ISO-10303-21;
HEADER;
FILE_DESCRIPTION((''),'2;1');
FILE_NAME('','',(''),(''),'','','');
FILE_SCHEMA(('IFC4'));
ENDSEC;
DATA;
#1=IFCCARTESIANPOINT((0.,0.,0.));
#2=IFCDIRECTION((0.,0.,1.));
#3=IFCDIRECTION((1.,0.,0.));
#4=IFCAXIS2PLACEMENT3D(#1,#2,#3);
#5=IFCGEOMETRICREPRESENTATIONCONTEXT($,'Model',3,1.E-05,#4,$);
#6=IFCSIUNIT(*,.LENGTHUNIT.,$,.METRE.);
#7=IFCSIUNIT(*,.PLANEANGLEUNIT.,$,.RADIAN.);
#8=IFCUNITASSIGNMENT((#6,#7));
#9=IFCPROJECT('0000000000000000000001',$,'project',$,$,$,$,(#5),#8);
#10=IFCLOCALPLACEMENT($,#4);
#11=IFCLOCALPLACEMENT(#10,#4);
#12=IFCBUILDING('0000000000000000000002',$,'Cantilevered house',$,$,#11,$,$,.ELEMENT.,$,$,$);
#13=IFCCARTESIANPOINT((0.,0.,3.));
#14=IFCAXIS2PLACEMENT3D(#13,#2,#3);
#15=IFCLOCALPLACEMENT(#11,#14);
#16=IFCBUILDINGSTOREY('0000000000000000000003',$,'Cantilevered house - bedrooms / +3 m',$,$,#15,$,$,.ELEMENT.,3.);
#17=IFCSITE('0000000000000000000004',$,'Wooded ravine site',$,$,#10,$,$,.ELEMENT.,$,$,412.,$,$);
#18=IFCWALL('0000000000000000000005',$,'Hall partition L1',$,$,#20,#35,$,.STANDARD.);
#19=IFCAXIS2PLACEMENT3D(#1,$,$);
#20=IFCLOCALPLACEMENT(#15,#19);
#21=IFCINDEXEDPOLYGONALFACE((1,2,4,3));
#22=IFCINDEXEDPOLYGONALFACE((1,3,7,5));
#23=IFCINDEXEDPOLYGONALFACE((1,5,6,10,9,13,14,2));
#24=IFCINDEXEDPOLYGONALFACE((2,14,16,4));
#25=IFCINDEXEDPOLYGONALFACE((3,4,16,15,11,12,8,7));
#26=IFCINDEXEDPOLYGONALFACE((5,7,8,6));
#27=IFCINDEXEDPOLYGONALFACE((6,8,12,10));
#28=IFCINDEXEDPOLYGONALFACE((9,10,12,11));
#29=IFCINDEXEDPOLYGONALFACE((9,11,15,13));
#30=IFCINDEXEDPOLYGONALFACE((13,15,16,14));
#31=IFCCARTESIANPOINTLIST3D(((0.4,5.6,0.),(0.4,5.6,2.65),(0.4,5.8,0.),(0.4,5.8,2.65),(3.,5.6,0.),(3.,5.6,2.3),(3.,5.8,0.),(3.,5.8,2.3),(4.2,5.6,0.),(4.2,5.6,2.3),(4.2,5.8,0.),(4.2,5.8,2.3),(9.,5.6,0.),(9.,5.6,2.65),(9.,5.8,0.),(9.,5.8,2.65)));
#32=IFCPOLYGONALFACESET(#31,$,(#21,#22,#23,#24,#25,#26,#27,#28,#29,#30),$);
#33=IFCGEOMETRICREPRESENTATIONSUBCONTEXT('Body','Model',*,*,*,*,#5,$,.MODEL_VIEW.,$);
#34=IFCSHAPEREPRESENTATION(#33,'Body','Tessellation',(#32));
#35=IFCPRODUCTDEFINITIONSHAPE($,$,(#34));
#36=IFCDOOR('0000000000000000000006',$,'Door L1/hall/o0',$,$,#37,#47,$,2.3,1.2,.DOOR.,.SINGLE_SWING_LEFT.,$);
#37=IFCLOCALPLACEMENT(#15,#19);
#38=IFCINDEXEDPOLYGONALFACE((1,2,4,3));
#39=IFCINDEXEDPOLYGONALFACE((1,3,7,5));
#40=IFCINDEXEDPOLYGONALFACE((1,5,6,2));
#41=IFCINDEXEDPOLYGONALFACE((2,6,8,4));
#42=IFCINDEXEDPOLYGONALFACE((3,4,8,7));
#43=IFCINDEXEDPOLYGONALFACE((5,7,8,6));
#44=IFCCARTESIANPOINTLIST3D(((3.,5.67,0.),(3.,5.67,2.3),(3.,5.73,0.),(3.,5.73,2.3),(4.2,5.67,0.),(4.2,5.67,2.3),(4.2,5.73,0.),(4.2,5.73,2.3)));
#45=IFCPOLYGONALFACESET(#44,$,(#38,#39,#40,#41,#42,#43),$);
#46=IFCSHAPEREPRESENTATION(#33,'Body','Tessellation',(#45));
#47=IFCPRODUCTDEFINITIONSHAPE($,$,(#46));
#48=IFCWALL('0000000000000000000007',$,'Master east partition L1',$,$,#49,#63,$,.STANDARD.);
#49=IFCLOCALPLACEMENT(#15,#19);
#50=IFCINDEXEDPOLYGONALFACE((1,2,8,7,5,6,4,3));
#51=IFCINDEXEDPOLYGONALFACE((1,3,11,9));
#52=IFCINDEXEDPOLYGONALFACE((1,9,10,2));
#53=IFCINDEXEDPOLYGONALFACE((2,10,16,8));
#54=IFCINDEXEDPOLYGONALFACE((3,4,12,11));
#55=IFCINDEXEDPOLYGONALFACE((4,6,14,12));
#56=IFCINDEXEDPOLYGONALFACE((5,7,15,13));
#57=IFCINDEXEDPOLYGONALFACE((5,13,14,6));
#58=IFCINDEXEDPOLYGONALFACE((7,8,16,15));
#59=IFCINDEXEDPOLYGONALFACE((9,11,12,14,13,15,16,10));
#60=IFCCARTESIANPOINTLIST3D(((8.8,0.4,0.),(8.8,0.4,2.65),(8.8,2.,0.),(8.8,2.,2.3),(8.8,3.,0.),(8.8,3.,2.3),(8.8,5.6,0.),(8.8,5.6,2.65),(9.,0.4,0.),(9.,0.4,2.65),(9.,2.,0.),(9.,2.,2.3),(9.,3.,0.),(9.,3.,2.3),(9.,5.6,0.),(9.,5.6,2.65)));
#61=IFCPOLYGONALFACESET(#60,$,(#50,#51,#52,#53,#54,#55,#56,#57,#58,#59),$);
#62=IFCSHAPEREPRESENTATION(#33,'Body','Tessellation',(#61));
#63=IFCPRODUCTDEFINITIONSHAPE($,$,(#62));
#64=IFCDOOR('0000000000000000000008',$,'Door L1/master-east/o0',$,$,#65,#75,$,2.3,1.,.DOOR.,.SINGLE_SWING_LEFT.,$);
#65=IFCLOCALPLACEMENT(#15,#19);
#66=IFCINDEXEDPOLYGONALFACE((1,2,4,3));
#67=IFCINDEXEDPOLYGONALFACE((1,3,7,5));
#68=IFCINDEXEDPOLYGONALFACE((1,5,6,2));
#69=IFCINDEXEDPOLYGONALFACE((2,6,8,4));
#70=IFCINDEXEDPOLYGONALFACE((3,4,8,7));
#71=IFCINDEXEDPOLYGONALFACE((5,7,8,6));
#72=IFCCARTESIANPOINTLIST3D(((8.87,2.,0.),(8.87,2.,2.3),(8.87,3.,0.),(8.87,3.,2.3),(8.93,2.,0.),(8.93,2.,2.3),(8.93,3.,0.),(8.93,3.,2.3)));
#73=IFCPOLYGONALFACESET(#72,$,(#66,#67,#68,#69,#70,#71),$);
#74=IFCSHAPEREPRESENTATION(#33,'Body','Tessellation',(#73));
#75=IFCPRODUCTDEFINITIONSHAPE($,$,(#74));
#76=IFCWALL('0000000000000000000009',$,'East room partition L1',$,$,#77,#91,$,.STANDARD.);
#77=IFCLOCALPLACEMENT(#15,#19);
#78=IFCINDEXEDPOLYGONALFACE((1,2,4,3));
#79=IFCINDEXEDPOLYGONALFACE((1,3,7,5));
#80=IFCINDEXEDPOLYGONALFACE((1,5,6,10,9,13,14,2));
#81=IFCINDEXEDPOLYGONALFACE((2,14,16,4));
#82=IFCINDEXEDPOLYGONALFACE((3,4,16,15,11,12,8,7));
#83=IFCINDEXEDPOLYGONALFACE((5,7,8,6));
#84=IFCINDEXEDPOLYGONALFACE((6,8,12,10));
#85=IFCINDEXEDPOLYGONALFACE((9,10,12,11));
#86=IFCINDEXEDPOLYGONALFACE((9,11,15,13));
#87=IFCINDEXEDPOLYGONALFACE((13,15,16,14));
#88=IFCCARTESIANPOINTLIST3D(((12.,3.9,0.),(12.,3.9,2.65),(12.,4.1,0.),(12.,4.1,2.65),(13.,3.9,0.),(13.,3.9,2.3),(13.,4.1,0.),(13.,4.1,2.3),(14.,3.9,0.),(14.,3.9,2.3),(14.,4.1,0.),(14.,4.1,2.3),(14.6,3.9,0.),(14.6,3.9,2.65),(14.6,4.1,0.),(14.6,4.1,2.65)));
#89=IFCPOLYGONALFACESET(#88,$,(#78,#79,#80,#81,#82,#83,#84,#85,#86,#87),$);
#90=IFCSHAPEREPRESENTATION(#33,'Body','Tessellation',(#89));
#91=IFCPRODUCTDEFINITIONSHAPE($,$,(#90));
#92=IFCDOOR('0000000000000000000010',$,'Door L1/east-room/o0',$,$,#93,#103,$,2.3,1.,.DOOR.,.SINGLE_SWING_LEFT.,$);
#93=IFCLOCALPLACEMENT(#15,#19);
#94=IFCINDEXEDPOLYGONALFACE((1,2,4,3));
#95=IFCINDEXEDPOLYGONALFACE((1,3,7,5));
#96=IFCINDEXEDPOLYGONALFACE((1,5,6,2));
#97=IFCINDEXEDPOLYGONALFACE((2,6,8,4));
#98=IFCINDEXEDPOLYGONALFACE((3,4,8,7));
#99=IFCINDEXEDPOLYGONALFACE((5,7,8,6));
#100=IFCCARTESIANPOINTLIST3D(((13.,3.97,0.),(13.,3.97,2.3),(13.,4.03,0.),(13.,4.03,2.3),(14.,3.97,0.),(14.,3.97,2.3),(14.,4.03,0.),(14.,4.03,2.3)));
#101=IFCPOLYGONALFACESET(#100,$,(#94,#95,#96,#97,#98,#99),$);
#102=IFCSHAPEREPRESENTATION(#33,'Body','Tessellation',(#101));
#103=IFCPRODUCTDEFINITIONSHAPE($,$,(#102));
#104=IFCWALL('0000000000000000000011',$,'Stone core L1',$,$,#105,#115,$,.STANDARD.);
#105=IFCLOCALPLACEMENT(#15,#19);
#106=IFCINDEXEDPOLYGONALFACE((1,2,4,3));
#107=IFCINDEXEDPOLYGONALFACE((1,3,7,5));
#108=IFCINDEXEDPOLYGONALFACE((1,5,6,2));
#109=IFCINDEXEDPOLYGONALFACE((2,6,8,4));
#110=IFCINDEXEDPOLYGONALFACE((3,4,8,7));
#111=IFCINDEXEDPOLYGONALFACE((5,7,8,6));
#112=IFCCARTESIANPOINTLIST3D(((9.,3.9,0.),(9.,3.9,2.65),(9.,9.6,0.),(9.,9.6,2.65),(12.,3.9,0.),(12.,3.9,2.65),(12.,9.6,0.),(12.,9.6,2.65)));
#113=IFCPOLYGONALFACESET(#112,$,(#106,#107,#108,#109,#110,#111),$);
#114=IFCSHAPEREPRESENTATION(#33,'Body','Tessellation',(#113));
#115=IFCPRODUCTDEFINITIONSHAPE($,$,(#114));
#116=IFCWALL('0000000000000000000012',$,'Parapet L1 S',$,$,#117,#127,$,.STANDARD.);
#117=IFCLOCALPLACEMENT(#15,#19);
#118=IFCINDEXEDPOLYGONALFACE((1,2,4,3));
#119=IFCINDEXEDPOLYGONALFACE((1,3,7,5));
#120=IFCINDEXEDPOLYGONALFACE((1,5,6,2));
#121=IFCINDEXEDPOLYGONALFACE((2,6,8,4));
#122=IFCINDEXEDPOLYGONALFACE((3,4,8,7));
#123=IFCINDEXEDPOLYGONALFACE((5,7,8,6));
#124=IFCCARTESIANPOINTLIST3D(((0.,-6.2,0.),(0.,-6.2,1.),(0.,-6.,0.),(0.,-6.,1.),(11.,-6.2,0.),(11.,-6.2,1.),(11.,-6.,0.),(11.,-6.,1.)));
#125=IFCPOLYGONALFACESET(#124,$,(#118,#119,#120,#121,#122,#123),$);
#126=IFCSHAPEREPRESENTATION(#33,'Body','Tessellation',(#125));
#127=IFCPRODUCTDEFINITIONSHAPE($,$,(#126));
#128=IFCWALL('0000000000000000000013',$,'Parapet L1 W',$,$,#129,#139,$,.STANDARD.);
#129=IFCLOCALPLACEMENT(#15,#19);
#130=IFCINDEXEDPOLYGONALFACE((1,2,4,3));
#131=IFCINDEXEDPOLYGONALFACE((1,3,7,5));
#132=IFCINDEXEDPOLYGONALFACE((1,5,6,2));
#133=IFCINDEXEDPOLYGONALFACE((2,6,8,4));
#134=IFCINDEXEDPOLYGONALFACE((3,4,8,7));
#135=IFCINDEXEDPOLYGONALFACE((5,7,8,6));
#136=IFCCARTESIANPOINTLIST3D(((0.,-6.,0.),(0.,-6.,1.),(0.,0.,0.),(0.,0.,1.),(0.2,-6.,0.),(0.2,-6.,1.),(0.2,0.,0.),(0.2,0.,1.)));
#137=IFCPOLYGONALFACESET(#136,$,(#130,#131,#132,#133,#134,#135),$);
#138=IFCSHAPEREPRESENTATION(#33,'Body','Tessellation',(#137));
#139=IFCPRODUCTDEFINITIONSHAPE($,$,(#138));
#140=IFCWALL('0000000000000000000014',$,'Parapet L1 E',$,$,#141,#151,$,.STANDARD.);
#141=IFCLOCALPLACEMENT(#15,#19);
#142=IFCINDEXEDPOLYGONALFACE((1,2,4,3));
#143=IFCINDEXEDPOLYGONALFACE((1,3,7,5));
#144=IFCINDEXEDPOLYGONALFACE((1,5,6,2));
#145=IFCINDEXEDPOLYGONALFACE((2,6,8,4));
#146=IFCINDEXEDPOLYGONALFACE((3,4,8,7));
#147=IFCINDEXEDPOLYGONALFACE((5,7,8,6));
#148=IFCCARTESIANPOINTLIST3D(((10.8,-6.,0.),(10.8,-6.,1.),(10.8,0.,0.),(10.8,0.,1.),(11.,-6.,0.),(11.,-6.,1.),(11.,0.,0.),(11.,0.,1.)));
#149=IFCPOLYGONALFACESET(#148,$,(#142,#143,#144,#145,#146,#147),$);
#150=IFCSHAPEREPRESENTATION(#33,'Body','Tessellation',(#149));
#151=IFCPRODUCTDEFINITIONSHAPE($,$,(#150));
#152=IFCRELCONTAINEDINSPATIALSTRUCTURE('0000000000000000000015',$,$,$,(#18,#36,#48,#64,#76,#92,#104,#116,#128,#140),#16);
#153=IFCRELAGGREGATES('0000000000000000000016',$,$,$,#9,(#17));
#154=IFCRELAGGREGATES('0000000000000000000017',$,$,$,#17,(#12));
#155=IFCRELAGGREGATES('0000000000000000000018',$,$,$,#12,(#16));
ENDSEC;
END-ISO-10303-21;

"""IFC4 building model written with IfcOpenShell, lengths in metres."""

from ifc_helpers import new_model, si_unit, frame, frame_2d, origin_with_axes, place, context, subcontext, project, spatial, rectangle, extrude, element, fill, save


model = new_model("IFC4")

# Units and contexts
model_context = context("Model", 3, precision=1e-05, world=origin_with_axes())
body_context = subcontext(model_context, "Body", "Model", "MODEL_VIEW")
ifc_project = project(units=[si_unit("LENGTHUNIT", "METRE"), si_unit("PLANEANGLEUNIT", "RADIAN")], contexts=[model_context])

# Site, building, storey
site_placement = place(None, origin_with_axes())
site = spatial("IfcSite", under=ifc_project, at=site_placement, Name="Wooded ravine site", CompositionType="ELEMENT", RefElevation=412.0)
building_placement = place(site_placement, origin_with_axes())
building = spatial("IfcBuilding", under=site, at=building_placement, Name="Cantilevered house", CompositionType="ELEMENT")
storey_placement = place(building_placement, frame((0.0, 0.0, 3.0), z_axis=(0.0, 0.0, 1.0), x_axis=(1.0, 0.0, 0.0)))
storey = spatial("IfcBuildingStorey", under=building, at=storey_placement, Name="Cantilevered house - bedrooms / +3 m", CompositionType="ELEMENT", Elevation=3.0)

# Walls, openings, doors
wall_1_placement = place(storey_placement, origin_with_axes())
wall_1 = element("IfcWall", 1, at=wall_1_placement, inside=storey, Name="Hall partition L1", PredefinedType="STANDARD", context=body_context, shape_type="SweptSolid", body=[
    extrude(rectangle(XDim=8.6, YDim=0.2, at=frame_2d((4.7, 5.7))), origin_with_axes(), (0.0, 0.0, 1.0), 2.65),
])
opening_1_placement = place(storey_placement, origin_with_axes())
opening_1 = element("IfcOpeningElement", 2, at=opening_1_placement, inside=storey, cuts=wall_1, PredefinedType="OPENING", context=body_context, shape_type="SweptSolid", body=[
    extrude(rectangle(XDim=1.2, YDim=0.24, at=frame_2d((3.6, 5.7))), origin_with_axes(), (0.0, 0.0, 1.0), 2.3),
])
door_1_placement = place(storey_placement, origin_with_axes())
door_1 = element("IfcDoor", 3, at=door_1_placement, inside=storey, Name="Door L1/hall/o0", OperationType="SINGLE_SWING_LEFT", OverallHeight=2.3, OverallWidth=1.2, PredefinedType="DOOR", context=body_context, shape_type="SweptSolid", body=[
    extrude(rectangle(XDim=1.2, YDim=0.06, at=frame_2d((3.6, 5.7))), origin_with_axes(), (0.0, 0.0, 1.0), 2.3),
])
fill(opening_1, door_1)
wall_2_placement = place(storey_placement, origin_with_axes())
wall_2 = element("IfcWall", 4, at=wall_2_placement, inside=storey, Name="Master east partition L1", PredefinedType="STANDARD", context=body_context, shape_type="SweptSolid", body=[
    extrude(rectangle(XDim=0.2, YDim=5.2, at=frame_2d((8.9, 3.0))), origin_with_axes(), (0.0, 0.0, 1.0), 2.65),
])
opening_2_placement = place(storey_placement, origin_with_axes())
opening_2 = element("IfcOpeningElement", 5, at=opening_2_placement, inside=storey, cuts=wall_2, PredefinedType="OPENING", context=body_context, shape_type="SweptSolid", body=[
    extrude(rectangle(XDim=0.24, YDim=1.0, at=frame_2d((8.9, 2.5))), origin_with_axes(), (0.0, 0.0, 1.0), 2.3),
])
door_2_placement = place(storey_placement, origin_with_axes())
door_2 = element("IfcDoor", 6, at=door_2_placement, inside=storey, Name="Door L1/master-east/o0", OperationType="SINGLE_SWING_LEFT", OverallHeight=2.3, OverallWidth=1.0, PredefinedType="DOOR", context=body_context, shape_type="SweptSolid", body=[
    extrude(rectangle(XDim=0.06, YDim=1.0, at=frame_2d((8.9, 2.5))), origin_with_axes(), (0.0, 0.0, 1.0), 2.3),
])
fill(opening_2, door_2)
wall_3_placement = place(storey_placement, origin_with_axes())
wall_3 = element("IfcWall", 7, at=wall_3_placement, inside=storey, Name="East room partition L1", PredefinedType="STANDARD", context=body_context, shape_type="SweptSolid", body=[
    extrude(rectangle(XDim=2.6, YDim=0.2, at=frame_2d((13.3, 4.0))), origin_with_axes(), (0.0, 0.0, 1.0), 2.65),
])
opening_3_placement = place(storey_placement, origin_with_axes())
opening_3 = element("IfcOpeningElement", 8, at=opening_3_placement, inside=storey, cuts=wall_3, PredefinedType="OPENING", context=body_context, shape_type="SweptSolid", body=[
    extrude(rectangle(XDim=1.0, YDim=0.24, at=frame_2d((13.5, 4.0))), origin_with_axes(), (0.0, 0.0, 1.0), 2.3),
])
door_3_placement = place(storey_placement, origin_with_axes())
door_3 = element("IfcDoor", 9, at=door_3_placement, inside=storey, Name="Door L1/east-room/o0", OperationType="SINGLE_SWING_LEFT", OverallHeight=2.3, OverallWidth=1.0, PredefinedType="DOOR", context=body_context, shape_type="SweptSolid", body=[
    extrude(rectangle(XDim=1.0, YDim=0.06, at=frame_2d((13.5, 4.0))), origin_with_axes(), (0.0, 0.0, 1.0), 2.3),
])
fill(opening_3, door_3)

# Walls
wall_4_placement = place(storey_placement, origin_with_axes())
element("IfcWall", 10, at=wall_4_placement, inside=storey, Name="Stone core L1", PredefinedType="STANDARD", context=body_context, shape_type="SweptSolid", body=[
    extrude(rectangle(XDim=3.0, YDim=5.7, at=frame_2d((10.5, 6.75))), origin_with_axes(), (0.0, 0.0, 1.0), 2.65),
])
wall_5_placement = place(storey_placement, origin_with_axes())
element("IfcWall", 11, at=wall_5_placement, inside=storey, Name="Parapet L1 S", PredefinedType="STANDARD", context=body_context, shape_type="SweptSolid", body=[
    extrude(rectangle(XDim=11.0, YDim=0.2, at=frame_2d((5.5, -6.1))), origin_with_axes(), (0.0, 0.0, 1.0), 1.0),
])
wall_6_placement = place(storey_placement, origin_with_axes())
element("IfcWall", 12, at=wall_6_placement, inside=storey, Name="Parapet L1 W", PredefinedType="STANDARD", context=body_context, shape_type="SweptSolid", body=[
    extrude(rectangle(XDim=0.2, YDim=6.0, at=frame_2d((0.1, -3.0))), origin_with_axes(), (0.0, 0.0, 1.0), 1.0),
])
wall_7_placement = place(storey_placement, origin_with_axes())
element("IfcWall", 13, at=wall_7_placement, inside=storey, Name="Parapet L1 E", PredefinedType="STANDARD", context=body_context, shape_type="SweptSolid", body=[
    extrude(rectangle(XDim=0.2, YDim=6.0, at=frame_2d((10.9, -3.0))), origin_with_axes(), (0.0, 0.0, 1.0), 1.0),
])

save(model, "model.ifc")
